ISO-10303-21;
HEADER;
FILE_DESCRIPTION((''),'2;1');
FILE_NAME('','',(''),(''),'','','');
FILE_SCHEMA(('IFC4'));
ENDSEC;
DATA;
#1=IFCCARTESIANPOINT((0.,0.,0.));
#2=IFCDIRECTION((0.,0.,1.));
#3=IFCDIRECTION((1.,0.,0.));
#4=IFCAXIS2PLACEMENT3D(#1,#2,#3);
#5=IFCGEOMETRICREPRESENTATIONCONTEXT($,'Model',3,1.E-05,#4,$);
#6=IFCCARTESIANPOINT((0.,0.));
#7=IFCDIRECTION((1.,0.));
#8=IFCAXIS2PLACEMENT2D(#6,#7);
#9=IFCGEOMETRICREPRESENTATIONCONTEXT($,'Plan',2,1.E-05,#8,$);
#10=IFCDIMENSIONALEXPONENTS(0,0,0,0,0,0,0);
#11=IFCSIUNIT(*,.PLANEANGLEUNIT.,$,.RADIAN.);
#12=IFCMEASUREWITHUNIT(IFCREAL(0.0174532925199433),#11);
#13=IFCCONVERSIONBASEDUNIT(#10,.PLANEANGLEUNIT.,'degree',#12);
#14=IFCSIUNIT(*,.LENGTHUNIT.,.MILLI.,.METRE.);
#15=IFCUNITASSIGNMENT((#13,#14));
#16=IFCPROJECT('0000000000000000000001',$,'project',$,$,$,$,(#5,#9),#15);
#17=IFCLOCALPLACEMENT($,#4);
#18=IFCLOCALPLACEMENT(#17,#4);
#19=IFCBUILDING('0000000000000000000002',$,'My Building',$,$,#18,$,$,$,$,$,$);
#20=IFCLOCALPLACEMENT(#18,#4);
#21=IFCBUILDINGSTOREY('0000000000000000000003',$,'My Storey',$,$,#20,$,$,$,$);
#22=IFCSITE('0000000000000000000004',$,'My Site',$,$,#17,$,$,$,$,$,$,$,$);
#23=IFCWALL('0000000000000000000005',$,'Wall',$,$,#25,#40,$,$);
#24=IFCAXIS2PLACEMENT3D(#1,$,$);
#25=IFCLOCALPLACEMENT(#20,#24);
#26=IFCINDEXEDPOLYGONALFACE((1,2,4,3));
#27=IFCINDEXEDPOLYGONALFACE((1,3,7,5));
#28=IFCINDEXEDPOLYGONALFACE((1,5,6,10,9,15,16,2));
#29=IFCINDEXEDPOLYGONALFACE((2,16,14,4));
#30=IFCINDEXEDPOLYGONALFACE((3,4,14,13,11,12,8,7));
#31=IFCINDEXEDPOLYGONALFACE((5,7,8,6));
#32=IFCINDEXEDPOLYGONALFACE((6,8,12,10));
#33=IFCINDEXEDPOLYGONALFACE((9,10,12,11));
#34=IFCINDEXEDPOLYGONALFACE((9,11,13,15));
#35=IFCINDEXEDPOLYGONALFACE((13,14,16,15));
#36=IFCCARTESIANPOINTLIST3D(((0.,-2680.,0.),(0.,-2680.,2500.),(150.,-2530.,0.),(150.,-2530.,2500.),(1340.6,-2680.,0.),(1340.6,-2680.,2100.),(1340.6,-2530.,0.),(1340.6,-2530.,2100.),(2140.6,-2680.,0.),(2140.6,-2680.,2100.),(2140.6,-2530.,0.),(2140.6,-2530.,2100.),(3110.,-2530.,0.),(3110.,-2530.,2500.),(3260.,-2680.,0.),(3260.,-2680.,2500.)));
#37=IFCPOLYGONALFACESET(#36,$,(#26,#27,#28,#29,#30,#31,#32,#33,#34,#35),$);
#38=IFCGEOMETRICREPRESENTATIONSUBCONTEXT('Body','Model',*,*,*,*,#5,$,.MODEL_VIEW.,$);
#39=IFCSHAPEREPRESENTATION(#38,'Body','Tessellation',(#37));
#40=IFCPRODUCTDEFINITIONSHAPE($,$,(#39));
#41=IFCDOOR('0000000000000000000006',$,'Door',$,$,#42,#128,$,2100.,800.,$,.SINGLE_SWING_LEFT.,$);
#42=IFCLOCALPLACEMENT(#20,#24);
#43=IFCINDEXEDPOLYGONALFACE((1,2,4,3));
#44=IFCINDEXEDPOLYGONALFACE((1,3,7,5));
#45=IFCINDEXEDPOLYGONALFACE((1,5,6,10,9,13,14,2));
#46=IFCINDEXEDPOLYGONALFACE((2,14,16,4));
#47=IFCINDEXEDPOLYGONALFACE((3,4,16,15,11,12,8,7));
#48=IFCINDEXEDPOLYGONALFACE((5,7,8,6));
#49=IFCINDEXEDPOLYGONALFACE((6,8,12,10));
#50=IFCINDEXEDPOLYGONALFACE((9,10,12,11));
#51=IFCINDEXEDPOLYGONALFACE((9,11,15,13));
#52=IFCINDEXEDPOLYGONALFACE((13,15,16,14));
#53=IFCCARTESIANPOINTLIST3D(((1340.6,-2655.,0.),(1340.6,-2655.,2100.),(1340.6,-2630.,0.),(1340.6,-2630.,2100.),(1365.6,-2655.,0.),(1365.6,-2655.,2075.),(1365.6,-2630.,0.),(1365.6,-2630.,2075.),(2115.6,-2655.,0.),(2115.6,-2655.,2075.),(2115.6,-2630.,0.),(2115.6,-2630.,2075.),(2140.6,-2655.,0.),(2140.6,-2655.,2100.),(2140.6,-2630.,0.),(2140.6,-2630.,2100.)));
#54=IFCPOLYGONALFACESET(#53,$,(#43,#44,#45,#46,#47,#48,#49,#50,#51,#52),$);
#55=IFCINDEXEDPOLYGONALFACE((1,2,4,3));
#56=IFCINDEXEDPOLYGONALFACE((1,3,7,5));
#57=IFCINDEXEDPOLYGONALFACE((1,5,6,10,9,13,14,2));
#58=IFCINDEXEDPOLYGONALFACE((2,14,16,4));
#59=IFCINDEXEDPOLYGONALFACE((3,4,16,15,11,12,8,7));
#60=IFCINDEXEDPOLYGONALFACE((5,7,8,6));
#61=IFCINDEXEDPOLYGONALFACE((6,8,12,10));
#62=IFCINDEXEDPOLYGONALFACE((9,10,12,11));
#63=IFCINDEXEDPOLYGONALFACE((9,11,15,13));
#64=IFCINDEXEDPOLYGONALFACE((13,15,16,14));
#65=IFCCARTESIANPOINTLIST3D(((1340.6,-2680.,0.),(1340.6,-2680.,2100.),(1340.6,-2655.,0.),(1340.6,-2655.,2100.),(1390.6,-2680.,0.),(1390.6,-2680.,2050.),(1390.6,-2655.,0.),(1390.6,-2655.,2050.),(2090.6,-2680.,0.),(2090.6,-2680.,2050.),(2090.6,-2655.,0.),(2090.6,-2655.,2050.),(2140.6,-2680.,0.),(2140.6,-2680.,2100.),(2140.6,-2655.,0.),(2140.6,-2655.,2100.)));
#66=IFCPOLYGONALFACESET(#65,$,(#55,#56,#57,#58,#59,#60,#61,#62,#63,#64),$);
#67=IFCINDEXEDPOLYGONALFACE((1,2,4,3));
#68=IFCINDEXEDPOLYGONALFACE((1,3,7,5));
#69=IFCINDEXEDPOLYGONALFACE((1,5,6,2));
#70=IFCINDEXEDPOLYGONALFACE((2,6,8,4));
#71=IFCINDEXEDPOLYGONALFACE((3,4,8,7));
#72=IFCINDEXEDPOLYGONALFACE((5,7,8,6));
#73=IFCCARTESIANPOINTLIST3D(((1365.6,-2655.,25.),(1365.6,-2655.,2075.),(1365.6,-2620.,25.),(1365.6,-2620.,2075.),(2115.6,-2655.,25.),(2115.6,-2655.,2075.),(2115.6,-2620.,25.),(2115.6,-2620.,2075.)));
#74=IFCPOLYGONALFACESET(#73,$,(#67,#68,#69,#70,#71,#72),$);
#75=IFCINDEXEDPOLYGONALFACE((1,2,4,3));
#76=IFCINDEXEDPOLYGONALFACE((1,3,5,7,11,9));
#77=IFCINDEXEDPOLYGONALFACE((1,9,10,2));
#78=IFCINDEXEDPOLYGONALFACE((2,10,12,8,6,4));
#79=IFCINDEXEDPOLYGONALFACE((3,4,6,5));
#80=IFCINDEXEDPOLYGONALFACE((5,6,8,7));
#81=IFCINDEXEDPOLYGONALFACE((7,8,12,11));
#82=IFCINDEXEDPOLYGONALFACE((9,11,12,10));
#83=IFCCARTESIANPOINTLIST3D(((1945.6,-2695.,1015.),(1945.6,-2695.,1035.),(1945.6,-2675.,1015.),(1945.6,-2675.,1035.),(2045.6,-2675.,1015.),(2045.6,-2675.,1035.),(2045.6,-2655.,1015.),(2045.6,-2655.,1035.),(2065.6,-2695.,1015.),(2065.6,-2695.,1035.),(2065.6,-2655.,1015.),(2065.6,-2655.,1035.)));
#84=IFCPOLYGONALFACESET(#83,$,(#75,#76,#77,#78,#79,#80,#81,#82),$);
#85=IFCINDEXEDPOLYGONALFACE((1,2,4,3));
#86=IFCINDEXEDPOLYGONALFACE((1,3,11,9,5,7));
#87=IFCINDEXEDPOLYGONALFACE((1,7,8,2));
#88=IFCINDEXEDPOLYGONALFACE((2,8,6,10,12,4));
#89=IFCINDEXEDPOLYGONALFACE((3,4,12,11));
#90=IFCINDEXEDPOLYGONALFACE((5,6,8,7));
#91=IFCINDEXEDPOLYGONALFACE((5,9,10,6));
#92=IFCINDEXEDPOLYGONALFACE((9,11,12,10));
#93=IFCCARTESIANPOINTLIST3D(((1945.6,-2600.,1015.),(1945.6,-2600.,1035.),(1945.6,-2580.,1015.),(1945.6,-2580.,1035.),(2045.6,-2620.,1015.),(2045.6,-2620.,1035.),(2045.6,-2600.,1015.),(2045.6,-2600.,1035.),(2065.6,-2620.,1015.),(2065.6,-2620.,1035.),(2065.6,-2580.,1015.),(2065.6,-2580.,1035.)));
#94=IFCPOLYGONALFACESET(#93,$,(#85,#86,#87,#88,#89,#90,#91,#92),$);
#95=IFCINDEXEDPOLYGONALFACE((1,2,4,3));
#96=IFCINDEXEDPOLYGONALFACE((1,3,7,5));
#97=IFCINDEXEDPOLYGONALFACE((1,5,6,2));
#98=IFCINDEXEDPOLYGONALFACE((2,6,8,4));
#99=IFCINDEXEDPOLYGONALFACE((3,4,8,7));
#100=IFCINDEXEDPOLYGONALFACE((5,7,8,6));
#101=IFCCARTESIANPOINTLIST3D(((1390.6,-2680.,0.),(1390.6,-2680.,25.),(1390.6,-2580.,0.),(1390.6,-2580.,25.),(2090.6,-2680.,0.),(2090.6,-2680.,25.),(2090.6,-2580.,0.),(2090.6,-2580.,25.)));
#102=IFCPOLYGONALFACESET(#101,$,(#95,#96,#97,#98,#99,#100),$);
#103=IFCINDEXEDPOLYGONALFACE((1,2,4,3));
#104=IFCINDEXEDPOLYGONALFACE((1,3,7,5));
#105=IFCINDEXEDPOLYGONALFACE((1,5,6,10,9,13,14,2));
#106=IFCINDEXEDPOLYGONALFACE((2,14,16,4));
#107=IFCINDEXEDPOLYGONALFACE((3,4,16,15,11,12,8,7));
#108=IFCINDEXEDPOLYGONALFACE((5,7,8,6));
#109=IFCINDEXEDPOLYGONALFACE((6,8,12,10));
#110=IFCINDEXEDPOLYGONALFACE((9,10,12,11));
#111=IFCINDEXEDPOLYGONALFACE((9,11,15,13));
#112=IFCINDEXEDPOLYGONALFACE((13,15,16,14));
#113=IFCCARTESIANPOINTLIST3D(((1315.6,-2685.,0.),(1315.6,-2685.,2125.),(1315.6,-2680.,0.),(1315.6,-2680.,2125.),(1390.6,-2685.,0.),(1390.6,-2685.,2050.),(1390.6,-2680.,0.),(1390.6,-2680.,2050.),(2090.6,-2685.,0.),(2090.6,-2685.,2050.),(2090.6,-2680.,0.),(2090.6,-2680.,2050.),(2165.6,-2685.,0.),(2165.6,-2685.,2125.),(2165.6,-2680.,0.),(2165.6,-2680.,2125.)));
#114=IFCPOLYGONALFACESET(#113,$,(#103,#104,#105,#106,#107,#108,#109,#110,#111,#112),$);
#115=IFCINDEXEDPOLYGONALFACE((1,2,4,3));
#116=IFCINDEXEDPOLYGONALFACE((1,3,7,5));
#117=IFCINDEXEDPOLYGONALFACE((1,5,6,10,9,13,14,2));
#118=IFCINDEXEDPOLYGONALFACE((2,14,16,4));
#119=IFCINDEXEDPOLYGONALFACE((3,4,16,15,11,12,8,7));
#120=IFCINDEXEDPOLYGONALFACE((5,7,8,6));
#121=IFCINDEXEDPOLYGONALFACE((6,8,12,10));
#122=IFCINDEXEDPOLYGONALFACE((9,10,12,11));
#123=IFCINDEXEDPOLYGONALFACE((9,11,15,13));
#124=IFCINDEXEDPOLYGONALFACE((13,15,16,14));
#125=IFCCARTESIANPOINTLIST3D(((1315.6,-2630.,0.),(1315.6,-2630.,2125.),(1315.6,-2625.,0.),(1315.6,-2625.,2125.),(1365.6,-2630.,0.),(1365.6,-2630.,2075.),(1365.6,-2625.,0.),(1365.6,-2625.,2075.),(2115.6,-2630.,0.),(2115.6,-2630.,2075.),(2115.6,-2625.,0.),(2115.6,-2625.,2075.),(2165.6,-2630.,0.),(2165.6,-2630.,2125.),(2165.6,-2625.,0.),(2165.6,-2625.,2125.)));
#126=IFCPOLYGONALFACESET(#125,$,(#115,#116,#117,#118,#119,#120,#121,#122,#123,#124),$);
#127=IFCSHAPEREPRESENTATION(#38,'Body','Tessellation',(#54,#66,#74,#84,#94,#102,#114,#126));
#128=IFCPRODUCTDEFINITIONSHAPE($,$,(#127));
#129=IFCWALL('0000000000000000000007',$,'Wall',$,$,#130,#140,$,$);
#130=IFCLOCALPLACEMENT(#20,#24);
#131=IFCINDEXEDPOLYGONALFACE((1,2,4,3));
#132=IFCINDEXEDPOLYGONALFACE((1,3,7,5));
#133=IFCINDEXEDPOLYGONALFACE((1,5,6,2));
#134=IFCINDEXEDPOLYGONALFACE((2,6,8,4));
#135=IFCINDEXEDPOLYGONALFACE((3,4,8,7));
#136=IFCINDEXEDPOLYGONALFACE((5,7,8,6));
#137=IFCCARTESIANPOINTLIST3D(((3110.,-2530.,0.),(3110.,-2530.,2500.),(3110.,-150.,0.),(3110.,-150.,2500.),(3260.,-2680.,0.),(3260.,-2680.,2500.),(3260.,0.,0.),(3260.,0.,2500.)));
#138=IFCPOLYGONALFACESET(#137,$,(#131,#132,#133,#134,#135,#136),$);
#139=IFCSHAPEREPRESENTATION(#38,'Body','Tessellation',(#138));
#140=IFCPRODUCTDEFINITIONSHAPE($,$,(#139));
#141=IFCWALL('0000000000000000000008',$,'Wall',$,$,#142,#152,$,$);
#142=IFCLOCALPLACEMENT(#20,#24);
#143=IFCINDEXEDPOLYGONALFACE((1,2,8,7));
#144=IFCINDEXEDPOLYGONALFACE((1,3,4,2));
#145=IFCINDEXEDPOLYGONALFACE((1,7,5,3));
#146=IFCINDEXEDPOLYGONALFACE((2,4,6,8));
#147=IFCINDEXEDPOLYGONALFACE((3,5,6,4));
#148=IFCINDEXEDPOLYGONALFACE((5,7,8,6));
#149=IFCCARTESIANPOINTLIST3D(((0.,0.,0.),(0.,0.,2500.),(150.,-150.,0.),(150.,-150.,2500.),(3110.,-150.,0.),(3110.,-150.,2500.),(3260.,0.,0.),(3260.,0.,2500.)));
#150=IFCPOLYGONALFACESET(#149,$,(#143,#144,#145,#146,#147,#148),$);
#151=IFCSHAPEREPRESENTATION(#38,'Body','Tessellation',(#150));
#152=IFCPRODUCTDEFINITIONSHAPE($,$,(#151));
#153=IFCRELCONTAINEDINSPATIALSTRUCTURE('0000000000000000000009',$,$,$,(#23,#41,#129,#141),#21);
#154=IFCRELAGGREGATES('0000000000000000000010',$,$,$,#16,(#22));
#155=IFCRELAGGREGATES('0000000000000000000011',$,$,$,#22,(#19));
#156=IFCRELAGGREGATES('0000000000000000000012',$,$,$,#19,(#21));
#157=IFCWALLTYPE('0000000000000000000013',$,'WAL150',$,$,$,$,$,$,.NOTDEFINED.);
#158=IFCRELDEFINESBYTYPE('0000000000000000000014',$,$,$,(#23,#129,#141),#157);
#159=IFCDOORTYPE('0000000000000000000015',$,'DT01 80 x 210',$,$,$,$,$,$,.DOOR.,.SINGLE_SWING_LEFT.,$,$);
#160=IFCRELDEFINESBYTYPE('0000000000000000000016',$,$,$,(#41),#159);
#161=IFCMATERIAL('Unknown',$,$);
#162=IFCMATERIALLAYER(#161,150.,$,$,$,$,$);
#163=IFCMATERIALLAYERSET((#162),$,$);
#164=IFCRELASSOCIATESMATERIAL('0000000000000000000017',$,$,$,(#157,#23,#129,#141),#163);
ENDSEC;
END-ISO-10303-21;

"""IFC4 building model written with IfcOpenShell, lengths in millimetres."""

from ifc_helpers import new_model, entity, si_unit, converted_unit, frame, origin_with_axes, origin_2d_with_axis, place, context, subcontext, project, spatial, line, indexed_curve, outline, extrude, shape, source, transform, mapped, material, layer, layer_set, layer_usage, type_object, type_shapes, element, fill, save


model = new_model("IFC4")

# Units and contexts
model_context = context("Model", 3, precision=1e-05, world=origin_with_axes())
plan_context = context("Plan", 2, precision=1e-05, world=origin_2d_with_axis())
body_context_1 = subcontext(model_context, "Body", "Model", "MODEL_VIEW")
body_context_2 = subcontext(plan_context, "Body", "Plan", "PLAN_VIEW")
ifc_project = project(units=[converted_unit("PLANEANGLEUNIT", "degree", entity("IfcReal", 0.0174532925199433), si_unit("PLANEANGLEUNIT", "RADIAN"), dimensions=[0, 0, 0, 0, 0, 0, 0]), si_unit("LENGTHUNIT", "METRE", prefix="MILLI")], contexts=[model_context, plan_context])

# Site, building, storey
site_placement = place(None, origin_with_axes())
site = spatial("IfcSite", under=ifc_project, at=site_placement, Name="My Site")
building_placement = place(site_placement, origin_with_axes())
building = spatial("IfcBuilding", under=site, at=building_placement, Name="My Building")
storey_placement = place(building_placement, origin_with_axes())
storey = spatial("IfcBuildingStorey", under=building, at=storey_placement, Name="My Storey")

# Shared definitions
ifc_material = material(Name="Unknown")

# Shared definitions
ifc_layer_1 = layer(ifc_material, 150.0)
ifc_layer_set_1 = layer_set([ifc_layer_1])
wall_type_1 = type_object("IfcWallType", Name="WAL150", PredefinedType="NOTDEFINED", material=ifc_layer_set_1)

# Wall, opening, door
ifc_layer_usage_1 = layer_usage(ifc_layer_set_1, "AXIS2", "POSITIVE", 0.0)
wall_1_placement = place(storey_placement, frame((0.0, -2680.0, 0.0), z_axis=(0.0, 0.0, 1.0), x_axis=(1.0, 0.0, 0.0)))
wall_1 = element("IfcWall", 1, at=wall_1_placement, inside=storey, type_object=wall_type_1, material=ifc_layer_usage_1, Name="Wall", context=body_context_1, shape_type="SweptSolid", body=[
    extrude(outline(indexed_curve([(0.0, 0.0), (150.0, 150.0), (3110.0, 150.0), (3260.0, 0.0)], segments=[line(1, 2, 3, 4, 1)])), origin_with_axes(), (0.0, 0.0, 1.0), 2500.0),
])
shared_shape_1 = source(origin_with_axes(), body_context_1, "Body", "SweptSolid", [
    extrude(outline(indexed_curve([(0.0, 0.0), (800.0, 0.0), (800.0, 2100.0), (0.0, 2100.0)], segments=[line(1, 2, 3, 4, 1)])), frame((0.0, -600.0, 0.0), z_axis=(0.0, -1.0, 0.0), x_axis=(1.0, 0.0, 0.0)), (0.0, 0.0, -1.0), 1200.0),
])
opening_1_placement = place(wall_1_placement, frame((1340.6, 0.0, 0.0), z_axis=(0.0, 0.0, 1.0), x_axis=(1.0, 0.0, 0.0)))
opening_1 = element("IfcOpeningElement", 2, at=opening_1_placement, cuts=wall_1, PredefinedType="OPENING", context=body_context_1, shape_type="MappedRepresentation", body=[
    mapped(shared_shape_1, transform((0.0, 0.0, 0.0), x_axis=(1.0, 0.0, 0.0), y_axis=(0.0, 1.0, 0.0), z_axis=(0.0, 0.0, 1.0), scale=1.0)),
])
door_type = type_object("IfcDoorType", Name="DT01 80 x 210", OperationType="SINGLE_SWING_LEFT", PredefinedType="DOOR")
shared_shape_2 = source(origin_with_axes(), body_context_1, "Body", "SweptSolid", [
    extrude(outline(indexed_curve([(0.0, 0.0), (0.0, 2100.0), (800.0, 2100.0), (800.0, 0.0), (775.0, 0.0), (775.0, 2075.0), (25.0, 2075.0), (25.0, 0.0)], segments=[line(1, 2, 3, 4, 5, 6, 7, 8, 1)])), frame((0.0, 25.0, 0.0), z_axis=(0.0, -1.0, 0.0), x_axis=(1.0, 0.0, 0.0)), (0.0, 0.0, -1.0), 25.0),
    extrude(outline(indexed_curve([(0.0, 0.0), (0.0, 2100.0), (800.0, 2100.0), (800.0, 0.0), (750.0, 0.0), (750.0, 2050.0), (50.0, 2050.0), (50.0, 0.0)], segments=[line(1, 2, 3, 4, 5, 6, 7, 8, 1)])), frame((0.0, 0.0, 0.0), z_axis=(0.0, -1.0, 0.0), x_axis=(1.0, 0.0, 0.0)), (0.0, 0.0, -1.0), 25.0),
    extrude(outline(indexed_curve([(0.0, 0.0), (750.0, 0.0), (750.0, 35.0), (0.0, 35.0)], segments=[line(1, 2, 3, 4, 1)])), frame((25.0, 25.0, 25.0), z_axis=(0.0, 0.0, 1.0), x_axis=(1.0, 0.0, 0.0)), (0.0, 0.0, 1.0), 2050.0),
    extrude(outline(indexed_curve([(0.0, 0.0), (0.0, -40.0), (-120.0, -40.0), (-120.0, -20.0), (-20.0, -20.0), (-20.0, 0.0)], segments=[line(1, 2, 3, 4, 5, 6, 1)])), frame((725.0, 25.0, 1015.0), z_axis=(0.0, 0.0, 1.0), x_axis=(1.0, 0.0, 0.0)), (0.0, 0.0, 1.0), 20.0),
    extrude(outline(indexed_curve([(0.0, 0.0), (0.0, 40.0), (-120.0, 40.0), (-120.0, 20.0), (-20.0, 20.0), (-20.0, 0.0)], segments=[line(1, 2, 3, 4, 5, 6, 1)])), frame((725.0, 60.0, 1015.0), z_axis=(0.0, 0.0, 1.0), x_axis=(1.0, 0.0, 0.0)), (0.0, 0.0, 1.0), 20.0),
    extrude(outline(indexed_curve([(0.0, 0.0), (700.0, 0.0), (700.0, 100.0), (0.0, 100.0), (0.0, 0.0)])), frame((50.0, 0.0, 0.0), z_axis=(0.0, 0.0, 1.0), x_axis=(1.0, 0.0, 0.0)), (0.0, 0.0, 1.0), 25.0),
    extrude(outline(indexed_curve([(75.0, 0.0), (75.0, 2050.0), (775.0, 2050.0), (775.0, 0.0), (850.0, 0.0), (850.0, 2125.0), (0.0, 2125.0), (0.0, 0.0), (75.0, 0.0)])), frame((-25.0, -5.0, 0.0), z_axis=(0.0, -1.0, 0.0), x_axis=(1.0, 0.0, 0.0)), (0.0, 0.0, -1.0), 5.0),
    extrude(outline(indexed_curve([(50.0, 0.0), (50.0, 2075.0), (800.0, 2075.0), (800.0, 0.0), (850.0, 0.0), (850.0, 2125.0), (0.0, 2125.0), (0.0, 0.0), (50.0, 0.0)])), frame((-25.0, 50.0, 0.0), z_axis=(0.0, -1.0, 0.0), x_axis=(1.0, 0.0, 0.0)), (0.0, 0.0, -1.0), 5.0),
])
shared_shape_3 = source(origin_with_axes(), body_context_2, "Body", "Curve2D", [
    entity("IfcIndexedPolyCurve", entity("IfcCartesianPointList2D", [[0.0, 0.0], [0.0, 50.0], [25.0, 50.0], [25.0, 25.0], [50.0, 25.0], [50.0, 0.0]]), [entity("IfcLineIndex", [1, 2, 3, 4, 5, 6, 1])]),
    entity("IfcIndexedPolyCurve", entity("IfcCartesianPointList2D", [[800.0, 0.0], [800.0, 50.0], [775.0, 50.0], [775.0, 25.0], [750.0, 25.0], [750.0, 0.0]]), [entity("IfcLineIndex", [1, 2, 3, 4, 5, 6, 1])]),
    entity("IfcTrimmedCurve", entity("IfcEllipse", entity("IfcAxis2Placement2D", entity("IfcCartesianPoint", [60.0, 50.0]), entity("IfcDirection", [1.0, 0.0])), 715.0, 750.0), [entity("IfcCartesianPoint", [775.0, 50.0])], [entity("IfcCartesianPoint", [60.0, 800.0])], True, "CARTESIAN"),
    entity("IfcIndexedPolyCurve", entity("IfcCartesianPointList2D", [[25.0, 50.0], [60.0, 50.0], [60.0, 800.0], [25.0, 800.0]]), [entity("IfcLineIndex", [1, 2, 3, 4, 1])]),
])
type_shapes(door_type, [shared_shape_2, shared_shape_3])
door_1_placement = place(opening_1_placement, origin_with_axes())
door_1 = element("IfcDoor", 3, at=door_1_placement, inside=storey, type_object=door_type, Name="Door", OperationType="SINGLE_SWING_LEFT", OverallHeight=2100.0, OverallWidth=800.0, shapes=[
    shape(body_context_1, "Body", "MappedRepresentation", [mapped(shared_shape_2, transform((0.0, 0.0, 0.0), x_axis=(1.0, 0.0, 0.0), y_axis=(0.0, 1.0, 0.0), z_axis=(0.0, 0.0, 1.0), scale=1.0))]),
    shape(body_context_2, "Body", "MappedRepresentation", [mapped(shared_shape_3, transform((0.0, 0.0, 0.0), x_axis=(1.0, 0.0, 0.0), y_axis=(0.0, 1.0, 0.0), z_axis=(0.0, 0.0, 1.0), scale=1.0))]),
])
fill(opening_1, door_1)

# Walls
ifc_layer_usage_2 = layer_usage(ifc_layer_set_1, "AXIS2", "POSITIVE", 0.0)
wall_2_placement = place(storey_placement, frame((3260.0, -2680.0, 0.0), z_axis=(0.0, 0.0, 1.0), x_axis=(0.0, 1.0, 0.0)))
element("IfcWall", 4, at=wall_2_placement, inside=storey, type_object=wall_type_1, material=ifc_layer_usage_2, Name="Wall", context=body_context_1, shape_type="SweptSolid", body=[
    extrude(outline(indexed_curve([(0.0, 0.0), (150.0, 150.0), (2530.0, 150.0), (2680.0, 0.0)], segments=[line(1, 2, 3, 4, 1)])), origin_with_axes(), (0.0, 0.0, 1.0), 2500.0),
])
ifc_layer_usage_3 = layer_usage(ifc_layer_set_1, "AXIS2", "POSITIVE", 0.0)
wall_3_placement = place(storey_placement, frame((3260.0, 0.0, 0.0), z_axis=(0.0, 0.0, 1.0), x_axis=(-1.0, 0.0, 0.0)))
element("IfcWall", 5, at=wall_3_placement, inside=storey, type_object=wall_type_1, material=ifc_layer_usage_3, Name="Wall", context=body_context_1, shape_type="SweptSolid", body=[
    extrude(outline(indexed_curve([(0.0, 0.0), (150.0, 150.0), (3110.0, 150.0), (3260.0, 0.0)], segments=[line(1, 2, 3, 4, 1)])), origin_with_axes(), (0.0, 0.0, 1.0), 2500.0),
])

save(model, "model.ifc")
